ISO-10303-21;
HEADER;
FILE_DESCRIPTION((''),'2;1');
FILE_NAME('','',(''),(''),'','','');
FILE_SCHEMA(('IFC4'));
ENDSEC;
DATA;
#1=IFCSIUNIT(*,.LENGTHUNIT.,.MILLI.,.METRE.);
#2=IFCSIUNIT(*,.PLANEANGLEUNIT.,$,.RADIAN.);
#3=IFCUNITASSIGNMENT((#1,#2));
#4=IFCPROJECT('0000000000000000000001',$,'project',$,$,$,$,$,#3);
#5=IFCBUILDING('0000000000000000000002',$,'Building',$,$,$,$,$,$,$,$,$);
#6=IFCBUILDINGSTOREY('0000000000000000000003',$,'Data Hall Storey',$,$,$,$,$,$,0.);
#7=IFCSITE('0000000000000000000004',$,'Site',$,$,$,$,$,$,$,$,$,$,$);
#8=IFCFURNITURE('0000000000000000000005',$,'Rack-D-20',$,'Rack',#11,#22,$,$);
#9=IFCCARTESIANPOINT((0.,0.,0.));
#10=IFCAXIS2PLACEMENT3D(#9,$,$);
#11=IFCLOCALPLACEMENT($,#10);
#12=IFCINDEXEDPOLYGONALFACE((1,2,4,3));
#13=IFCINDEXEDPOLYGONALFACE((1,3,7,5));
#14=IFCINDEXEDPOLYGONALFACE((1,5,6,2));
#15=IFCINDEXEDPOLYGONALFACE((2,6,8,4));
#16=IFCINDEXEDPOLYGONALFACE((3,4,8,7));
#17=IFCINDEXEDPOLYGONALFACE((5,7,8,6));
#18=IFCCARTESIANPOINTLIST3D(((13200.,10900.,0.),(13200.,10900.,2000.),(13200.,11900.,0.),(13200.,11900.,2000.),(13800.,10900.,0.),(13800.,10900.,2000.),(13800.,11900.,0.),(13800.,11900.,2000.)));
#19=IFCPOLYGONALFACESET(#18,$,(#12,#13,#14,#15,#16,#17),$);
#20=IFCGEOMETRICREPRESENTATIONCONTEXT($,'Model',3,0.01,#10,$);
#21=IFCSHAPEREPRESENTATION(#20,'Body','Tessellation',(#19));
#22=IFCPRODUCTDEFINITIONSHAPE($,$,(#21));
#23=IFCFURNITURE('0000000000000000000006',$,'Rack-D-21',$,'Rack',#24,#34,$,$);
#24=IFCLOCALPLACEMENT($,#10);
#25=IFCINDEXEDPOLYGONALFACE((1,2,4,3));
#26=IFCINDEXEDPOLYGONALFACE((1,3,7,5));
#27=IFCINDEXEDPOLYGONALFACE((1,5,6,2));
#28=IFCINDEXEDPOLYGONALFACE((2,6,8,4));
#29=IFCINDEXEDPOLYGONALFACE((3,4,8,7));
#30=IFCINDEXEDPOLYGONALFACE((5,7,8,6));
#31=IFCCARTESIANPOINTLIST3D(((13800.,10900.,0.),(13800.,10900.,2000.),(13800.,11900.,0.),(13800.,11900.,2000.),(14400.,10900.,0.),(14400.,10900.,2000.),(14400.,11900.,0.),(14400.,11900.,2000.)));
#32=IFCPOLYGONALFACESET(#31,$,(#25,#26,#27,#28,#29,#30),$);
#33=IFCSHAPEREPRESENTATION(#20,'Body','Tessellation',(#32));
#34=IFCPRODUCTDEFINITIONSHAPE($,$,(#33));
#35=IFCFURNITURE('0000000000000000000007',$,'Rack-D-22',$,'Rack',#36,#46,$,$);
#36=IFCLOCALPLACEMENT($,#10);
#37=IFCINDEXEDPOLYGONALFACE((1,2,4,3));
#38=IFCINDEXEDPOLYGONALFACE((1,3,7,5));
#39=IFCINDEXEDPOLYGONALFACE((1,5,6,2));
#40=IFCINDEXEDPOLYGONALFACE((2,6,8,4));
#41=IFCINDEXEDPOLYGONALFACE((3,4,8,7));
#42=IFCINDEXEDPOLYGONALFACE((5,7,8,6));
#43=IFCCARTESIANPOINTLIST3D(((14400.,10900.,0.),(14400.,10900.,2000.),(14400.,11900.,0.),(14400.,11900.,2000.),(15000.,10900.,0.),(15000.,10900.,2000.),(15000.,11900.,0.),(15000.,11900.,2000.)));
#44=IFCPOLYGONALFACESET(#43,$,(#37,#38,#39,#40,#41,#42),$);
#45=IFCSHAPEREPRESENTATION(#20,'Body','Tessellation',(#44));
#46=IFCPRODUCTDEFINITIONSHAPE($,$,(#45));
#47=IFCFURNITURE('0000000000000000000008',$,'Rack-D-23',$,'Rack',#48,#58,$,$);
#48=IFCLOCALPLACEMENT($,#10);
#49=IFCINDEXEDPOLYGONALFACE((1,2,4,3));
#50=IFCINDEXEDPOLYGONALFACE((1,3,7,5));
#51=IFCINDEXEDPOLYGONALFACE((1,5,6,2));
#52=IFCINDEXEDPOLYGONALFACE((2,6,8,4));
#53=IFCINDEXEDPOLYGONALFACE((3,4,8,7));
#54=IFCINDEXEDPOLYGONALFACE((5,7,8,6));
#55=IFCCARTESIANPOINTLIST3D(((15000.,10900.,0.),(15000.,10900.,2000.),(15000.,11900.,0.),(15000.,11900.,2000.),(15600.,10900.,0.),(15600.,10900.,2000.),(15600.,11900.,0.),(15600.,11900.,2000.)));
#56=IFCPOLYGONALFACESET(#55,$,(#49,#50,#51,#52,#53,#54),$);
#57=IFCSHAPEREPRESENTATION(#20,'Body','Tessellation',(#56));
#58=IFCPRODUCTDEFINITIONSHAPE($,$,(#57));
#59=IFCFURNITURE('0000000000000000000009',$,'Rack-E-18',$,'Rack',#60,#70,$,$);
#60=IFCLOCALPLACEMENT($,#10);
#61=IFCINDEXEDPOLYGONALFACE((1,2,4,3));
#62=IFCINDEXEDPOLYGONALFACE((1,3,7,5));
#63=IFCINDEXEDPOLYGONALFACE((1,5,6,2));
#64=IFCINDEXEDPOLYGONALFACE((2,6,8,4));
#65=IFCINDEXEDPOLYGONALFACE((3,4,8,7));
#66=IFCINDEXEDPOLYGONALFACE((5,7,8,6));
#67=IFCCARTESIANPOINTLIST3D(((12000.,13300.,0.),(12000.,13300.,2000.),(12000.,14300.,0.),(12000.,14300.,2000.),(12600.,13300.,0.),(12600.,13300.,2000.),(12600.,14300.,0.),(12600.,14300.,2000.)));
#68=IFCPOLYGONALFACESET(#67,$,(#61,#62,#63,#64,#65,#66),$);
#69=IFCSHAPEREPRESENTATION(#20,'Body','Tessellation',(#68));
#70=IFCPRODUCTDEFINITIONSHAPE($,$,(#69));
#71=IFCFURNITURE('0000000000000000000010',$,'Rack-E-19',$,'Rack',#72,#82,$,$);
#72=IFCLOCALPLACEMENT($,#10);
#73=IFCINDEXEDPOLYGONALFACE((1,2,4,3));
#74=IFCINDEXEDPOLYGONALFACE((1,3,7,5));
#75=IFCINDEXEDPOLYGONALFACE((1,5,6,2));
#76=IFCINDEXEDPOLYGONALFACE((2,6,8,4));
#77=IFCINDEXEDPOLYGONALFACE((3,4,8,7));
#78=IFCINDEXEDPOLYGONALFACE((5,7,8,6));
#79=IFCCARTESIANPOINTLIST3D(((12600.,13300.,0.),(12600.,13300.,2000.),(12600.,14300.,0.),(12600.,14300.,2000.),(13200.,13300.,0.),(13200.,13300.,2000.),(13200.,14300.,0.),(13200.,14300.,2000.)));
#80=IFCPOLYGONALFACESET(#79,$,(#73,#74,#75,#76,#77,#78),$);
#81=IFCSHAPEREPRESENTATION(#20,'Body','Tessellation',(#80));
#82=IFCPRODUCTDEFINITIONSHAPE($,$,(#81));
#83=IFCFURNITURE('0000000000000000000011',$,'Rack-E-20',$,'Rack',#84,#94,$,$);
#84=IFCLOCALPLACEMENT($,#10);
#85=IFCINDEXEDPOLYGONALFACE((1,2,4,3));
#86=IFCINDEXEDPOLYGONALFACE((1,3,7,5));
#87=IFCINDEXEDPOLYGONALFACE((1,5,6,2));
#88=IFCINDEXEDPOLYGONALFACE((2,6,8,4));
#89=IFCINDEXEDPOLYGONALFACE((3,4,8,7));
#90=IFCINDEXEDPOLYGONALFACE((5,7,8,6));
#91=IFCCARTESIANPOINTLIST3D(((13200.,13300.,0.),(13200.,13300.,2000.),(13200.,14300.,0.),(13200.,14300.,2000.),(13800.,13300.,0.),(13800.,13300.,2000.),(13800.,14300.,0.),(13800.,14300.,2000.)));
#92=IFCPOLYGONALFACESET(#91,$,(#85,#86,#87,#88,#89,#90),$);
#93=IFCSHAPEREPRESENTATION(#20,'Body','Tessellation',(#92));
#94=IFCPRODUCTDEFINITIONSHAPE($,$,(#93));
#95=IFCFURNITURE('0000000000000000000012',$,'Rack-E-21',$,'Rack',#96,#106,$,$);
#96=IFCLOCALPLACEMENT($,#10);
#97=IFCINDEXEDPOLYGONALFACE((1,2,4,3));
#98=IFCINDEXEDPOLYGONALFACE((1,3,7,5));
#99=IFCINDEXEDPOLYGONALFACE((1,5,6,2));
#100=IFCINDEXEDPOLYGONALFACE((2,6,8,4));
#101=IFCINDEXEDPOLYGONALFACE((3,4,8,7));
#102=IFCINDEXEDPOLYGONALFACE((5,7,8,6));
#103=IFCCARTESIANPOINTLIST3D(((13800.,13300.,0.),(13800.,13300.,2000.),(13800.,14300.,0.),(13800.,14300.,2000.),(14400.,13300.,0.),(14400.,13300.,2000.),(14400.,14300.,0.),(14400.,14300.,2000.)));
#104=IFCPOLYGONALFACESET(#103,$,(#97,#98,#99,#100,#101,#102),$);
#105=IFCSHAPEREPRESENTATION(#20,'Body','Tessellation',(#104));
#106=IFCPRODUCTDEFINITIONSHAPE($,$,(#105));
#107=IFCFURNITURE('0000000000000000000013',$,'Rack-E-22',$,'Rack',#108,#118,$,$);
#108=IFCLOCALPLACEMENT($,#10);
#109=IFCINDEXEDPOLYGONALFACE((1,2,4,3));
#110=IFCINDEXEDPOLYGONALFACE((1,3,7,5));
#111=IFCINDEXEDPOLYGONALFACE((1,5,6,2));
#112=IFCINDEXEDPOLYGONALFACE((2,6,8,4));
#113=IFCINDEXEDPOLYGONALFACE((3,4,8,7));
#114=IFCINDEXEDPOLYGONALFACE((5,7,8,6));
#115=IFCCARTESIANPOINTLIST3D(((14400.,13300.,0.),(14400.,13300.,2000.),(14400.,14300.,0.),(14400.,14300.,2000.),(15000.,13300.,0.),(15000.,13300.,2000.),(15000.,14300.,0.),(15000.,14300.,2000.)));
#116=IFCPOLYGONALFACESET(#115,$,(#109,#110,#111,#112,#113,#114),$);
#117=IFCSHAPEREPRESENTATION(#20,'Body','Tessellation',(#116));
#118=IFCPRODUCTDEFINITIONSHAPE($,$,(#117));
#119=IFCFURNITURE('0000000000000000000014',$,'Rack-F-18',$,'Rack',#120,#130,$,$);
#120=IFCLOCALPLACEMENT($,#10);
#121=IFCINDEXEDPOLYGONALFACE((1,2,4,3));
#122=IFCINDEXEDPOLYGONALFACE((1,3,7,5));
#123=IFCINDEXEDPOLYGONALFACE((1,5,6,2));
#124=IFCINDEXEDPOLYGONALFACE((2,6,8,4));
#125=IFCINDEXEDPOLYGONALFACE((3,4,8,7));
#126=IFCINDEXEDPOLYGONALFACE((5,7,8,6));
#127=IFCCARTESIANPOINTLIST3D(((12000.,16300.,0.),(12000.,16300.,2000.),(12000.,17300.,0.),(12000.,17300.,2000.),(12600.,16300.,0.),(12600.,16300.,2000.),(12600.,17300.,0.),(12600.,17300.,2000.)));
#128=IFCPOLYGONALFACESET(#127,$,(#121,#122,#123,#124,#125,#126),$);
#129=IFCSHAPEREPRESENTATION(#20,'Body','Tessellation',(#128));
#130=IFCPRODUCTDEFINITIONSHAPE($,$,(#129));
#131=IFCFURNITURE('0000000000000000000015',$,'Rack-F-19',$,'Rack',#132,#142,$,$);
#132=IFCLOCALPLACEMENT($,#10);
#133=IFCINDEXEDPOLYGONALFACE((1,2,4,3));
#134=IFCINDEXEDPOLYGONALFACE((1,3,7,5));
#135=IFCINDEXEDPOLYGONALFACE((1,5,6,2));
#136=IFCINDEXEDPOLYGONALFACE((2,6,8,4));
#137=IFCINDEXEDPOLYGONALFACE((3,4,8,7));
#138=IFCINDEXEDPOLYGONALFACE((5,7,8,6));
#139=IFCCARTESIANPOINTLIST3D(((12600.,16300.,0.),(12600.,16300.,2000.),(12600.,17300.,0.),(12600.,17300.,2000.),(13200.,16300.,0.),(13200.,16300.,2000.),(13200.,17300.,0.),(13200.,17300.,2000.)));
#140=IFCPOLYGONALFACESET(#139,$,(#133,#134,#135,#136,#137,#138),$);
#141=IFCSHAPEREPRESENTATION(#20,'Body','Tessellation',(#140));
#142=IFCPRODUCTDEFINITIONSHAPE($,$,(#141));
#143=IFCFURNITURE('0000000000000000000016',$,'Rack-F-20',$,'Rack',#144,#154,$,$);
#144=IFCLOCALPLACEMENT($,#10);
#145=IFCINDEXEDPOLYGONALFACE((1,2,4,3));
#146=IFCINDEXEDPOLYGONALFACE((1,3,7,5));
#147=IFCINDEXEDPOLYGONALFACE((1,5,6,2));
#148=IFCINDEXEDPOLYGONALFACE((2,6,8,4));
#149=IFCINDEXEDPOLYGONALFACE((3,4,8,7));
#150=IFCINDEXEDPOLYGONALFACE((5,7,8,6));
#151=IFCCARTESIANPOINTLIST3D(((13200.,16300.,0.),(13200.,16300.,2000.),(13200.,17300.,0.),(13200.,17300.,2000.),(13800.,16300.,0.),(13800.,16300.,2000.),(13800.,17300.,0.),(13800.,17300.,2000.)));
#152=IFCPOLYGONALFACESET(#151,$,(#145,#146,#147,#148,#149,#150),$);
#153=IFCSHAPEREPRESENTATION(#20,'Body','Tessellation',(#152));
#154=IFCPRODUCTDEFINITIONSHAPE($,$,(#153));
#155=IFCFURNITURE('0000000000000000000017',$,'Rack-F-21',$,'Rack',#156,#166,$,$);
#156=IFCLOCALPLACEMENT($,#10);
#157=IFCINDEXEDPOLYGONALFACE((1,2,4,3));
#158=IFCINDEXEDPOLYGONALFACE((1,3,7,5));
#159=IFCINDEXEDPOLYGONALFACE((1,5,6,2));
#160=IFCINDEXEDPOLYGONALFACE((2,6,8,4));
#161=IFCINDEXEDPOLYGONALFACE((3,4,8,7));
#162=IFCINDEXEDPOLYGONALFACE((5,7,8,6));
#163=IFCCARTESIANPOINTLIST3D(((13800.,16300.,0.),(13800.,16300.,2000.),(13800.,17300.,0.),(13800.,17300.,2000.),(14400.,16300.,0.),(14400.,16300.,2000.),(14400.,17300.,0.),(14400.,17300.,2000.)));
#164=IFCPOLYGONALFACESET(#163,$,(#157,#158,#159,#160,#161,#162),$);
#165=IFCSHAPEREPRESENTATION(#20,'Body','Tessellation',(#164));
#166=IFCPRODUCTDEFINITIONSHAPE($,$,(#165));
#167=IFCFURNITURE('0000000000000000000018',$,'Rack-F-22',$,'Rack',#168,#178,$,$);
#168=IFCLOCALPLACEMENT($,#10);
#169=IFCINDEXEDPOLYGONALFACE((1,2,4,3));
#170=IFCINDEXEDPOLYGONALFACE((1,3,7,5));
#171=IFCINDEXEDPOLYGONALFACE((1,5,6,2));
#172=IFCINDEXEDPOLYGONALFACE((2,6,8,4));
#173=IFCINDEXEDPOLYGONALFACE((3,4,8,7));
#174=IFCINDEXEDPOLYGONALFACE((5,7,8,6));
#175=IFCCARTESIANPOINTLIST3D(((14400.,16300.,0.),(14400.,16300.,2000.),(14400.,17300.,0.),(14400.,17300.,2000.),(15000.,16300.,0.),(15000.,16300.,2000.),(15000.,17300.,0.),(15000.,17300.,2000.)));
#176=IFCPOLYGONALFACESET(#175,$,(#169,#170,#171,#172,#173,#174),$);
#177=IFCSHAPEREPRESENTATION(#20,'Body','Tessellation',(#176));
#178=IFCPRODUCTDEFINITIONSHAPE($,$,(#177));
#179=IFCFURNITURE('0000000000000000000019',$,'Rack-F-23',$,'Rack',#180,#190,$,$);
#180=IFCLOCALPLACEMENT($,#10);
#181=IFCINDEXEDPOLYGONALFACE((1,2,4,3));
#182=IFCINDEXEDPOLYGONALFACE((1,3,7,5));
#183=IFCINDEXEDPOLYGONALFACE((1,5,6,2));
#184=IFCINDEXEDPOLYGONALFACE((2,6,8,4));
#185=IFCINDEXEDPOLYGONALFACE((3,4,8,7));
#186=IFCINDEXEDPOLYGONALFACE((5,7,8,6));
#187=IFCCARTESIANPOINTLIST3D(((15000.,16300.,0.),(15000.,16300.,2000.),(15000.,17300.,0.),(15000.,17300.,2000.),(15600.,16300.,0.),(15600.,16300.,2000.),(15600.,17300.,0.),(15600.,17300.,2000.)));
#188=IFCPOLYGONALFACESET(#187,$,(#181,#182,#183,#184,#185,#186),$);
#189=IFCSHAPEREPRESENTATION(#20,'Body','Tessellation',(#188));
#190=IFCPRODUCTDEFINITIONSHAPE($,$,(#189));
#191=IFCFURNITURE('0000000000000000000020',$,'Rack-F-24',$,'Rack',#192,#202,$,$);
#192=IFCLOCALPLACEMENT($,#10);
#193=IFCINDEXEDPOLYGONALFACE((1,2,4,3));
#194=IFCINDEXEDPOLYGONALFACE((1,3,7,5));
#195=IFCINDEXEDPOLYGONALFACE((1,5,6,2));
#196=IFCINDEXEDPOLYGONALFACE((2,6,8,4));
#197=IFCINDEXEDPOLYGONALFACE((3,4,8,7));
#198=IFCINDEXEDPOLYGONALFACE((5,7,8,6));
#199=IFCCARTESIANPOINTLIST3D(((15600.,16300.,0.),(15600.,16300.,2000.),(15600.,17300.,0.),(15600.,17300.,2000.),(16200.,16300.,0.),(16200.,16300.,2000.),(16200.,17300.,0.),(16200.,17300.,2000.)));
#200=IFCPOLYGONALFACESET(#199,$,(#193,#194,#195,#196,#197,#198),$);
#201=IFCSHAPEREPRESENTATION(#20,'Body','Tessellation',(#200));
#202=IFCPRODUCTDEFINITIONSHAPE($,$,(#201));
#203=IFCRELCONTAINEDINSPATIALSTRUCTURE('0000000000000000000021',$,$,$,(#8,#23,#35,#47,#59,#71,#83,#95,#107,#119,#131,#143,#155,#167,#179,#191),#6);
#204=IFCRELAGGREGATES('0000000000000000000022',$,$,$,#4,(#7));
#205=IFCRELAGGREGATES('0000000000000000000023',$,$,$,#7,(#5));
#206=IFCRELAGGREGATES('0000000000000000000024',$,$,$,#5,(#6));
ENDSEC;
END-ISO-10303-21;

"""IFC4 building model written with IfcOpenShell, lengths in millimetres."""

from ifc_helpers import new_model, si_unit, frame, origin, place, context, project, spatial, rectangle, extrude, element, save


model = new_model("IFC4")

# Units and contexts
model_context = context("Model", 3, precision=0.01, world=origin())
ifc_project = project(units=[si_unit("LENGTHUNIT", "METRE", prefix="MILLI"), si_unit("PLANEANGLEUNIT", "RADIAN")])

# Site, building, storey
site = spatial("IfcSite", under=ifc_project, Name="Site")
building = spatial("IfcBuilding", under=site, Name="Building")
storey = spatial("IfcBuildingStorey", under=building, Name="Data Hall Storey", Elevation=0.0)

# Furniture
for number, where, name in (
    (1, (13500.0, 11400.0, 0.0), "Rack-D-20"),
    (2, (14100.0, 11400.0, 0.0), "Rack-D-21"),
    (3, (14700.0, 11400.0, 0.0), "Rack-D-22"),
    (4, (15300.0, 11400.0, 0.0), "Rack-D-23"),
    (5, (12300.0, 13800.0, 0.0), "Rack-E-18"),
    (6, (12900.0, 13800.0, 0.0), "Rack-E-19"),
    (7, (13500.0, 13800.0, 0.0), "Rack-E-20"),
    (8, (14100.0, 13800.0, 0.0), "Rack-E-21"),
    (9, (14700.0, 13800.0, 0.0), "Rack-E-22"),
    (10, (12300.0, 16800.0, 0.0), "Rack-F-18"),
    (11, (12900.0, 16800.0, 0.0), "Rack-F-19"),
    (12, (13500.0, 16800.0, 0.0), "Rack-F-20"),
    (13, (14100.0, 16800.0, 0.0), "Rack-F-21"),
    (14, (14700.0, 16800.0, 0.0), "Rack-F-22"),
    (15, (15300.0, 16800.0, 0.0), "Rack-F-23"),
    (16, (15900.0, 16800.0, 0.0), "Rack-F-24"),
):
    element("IfcFurniture", number, at=place(None, frame(where)), inside=storey, Name=name, ObjectType="Rack", context=model_context, shape_type="SweptSolid", body=[
        extrude(rectangle(XDim=600.0, YDim=1000.0), origin(), (0.0, 0.0, 1.0), 2000.0),
    ])

save(model, "model.ifc")
